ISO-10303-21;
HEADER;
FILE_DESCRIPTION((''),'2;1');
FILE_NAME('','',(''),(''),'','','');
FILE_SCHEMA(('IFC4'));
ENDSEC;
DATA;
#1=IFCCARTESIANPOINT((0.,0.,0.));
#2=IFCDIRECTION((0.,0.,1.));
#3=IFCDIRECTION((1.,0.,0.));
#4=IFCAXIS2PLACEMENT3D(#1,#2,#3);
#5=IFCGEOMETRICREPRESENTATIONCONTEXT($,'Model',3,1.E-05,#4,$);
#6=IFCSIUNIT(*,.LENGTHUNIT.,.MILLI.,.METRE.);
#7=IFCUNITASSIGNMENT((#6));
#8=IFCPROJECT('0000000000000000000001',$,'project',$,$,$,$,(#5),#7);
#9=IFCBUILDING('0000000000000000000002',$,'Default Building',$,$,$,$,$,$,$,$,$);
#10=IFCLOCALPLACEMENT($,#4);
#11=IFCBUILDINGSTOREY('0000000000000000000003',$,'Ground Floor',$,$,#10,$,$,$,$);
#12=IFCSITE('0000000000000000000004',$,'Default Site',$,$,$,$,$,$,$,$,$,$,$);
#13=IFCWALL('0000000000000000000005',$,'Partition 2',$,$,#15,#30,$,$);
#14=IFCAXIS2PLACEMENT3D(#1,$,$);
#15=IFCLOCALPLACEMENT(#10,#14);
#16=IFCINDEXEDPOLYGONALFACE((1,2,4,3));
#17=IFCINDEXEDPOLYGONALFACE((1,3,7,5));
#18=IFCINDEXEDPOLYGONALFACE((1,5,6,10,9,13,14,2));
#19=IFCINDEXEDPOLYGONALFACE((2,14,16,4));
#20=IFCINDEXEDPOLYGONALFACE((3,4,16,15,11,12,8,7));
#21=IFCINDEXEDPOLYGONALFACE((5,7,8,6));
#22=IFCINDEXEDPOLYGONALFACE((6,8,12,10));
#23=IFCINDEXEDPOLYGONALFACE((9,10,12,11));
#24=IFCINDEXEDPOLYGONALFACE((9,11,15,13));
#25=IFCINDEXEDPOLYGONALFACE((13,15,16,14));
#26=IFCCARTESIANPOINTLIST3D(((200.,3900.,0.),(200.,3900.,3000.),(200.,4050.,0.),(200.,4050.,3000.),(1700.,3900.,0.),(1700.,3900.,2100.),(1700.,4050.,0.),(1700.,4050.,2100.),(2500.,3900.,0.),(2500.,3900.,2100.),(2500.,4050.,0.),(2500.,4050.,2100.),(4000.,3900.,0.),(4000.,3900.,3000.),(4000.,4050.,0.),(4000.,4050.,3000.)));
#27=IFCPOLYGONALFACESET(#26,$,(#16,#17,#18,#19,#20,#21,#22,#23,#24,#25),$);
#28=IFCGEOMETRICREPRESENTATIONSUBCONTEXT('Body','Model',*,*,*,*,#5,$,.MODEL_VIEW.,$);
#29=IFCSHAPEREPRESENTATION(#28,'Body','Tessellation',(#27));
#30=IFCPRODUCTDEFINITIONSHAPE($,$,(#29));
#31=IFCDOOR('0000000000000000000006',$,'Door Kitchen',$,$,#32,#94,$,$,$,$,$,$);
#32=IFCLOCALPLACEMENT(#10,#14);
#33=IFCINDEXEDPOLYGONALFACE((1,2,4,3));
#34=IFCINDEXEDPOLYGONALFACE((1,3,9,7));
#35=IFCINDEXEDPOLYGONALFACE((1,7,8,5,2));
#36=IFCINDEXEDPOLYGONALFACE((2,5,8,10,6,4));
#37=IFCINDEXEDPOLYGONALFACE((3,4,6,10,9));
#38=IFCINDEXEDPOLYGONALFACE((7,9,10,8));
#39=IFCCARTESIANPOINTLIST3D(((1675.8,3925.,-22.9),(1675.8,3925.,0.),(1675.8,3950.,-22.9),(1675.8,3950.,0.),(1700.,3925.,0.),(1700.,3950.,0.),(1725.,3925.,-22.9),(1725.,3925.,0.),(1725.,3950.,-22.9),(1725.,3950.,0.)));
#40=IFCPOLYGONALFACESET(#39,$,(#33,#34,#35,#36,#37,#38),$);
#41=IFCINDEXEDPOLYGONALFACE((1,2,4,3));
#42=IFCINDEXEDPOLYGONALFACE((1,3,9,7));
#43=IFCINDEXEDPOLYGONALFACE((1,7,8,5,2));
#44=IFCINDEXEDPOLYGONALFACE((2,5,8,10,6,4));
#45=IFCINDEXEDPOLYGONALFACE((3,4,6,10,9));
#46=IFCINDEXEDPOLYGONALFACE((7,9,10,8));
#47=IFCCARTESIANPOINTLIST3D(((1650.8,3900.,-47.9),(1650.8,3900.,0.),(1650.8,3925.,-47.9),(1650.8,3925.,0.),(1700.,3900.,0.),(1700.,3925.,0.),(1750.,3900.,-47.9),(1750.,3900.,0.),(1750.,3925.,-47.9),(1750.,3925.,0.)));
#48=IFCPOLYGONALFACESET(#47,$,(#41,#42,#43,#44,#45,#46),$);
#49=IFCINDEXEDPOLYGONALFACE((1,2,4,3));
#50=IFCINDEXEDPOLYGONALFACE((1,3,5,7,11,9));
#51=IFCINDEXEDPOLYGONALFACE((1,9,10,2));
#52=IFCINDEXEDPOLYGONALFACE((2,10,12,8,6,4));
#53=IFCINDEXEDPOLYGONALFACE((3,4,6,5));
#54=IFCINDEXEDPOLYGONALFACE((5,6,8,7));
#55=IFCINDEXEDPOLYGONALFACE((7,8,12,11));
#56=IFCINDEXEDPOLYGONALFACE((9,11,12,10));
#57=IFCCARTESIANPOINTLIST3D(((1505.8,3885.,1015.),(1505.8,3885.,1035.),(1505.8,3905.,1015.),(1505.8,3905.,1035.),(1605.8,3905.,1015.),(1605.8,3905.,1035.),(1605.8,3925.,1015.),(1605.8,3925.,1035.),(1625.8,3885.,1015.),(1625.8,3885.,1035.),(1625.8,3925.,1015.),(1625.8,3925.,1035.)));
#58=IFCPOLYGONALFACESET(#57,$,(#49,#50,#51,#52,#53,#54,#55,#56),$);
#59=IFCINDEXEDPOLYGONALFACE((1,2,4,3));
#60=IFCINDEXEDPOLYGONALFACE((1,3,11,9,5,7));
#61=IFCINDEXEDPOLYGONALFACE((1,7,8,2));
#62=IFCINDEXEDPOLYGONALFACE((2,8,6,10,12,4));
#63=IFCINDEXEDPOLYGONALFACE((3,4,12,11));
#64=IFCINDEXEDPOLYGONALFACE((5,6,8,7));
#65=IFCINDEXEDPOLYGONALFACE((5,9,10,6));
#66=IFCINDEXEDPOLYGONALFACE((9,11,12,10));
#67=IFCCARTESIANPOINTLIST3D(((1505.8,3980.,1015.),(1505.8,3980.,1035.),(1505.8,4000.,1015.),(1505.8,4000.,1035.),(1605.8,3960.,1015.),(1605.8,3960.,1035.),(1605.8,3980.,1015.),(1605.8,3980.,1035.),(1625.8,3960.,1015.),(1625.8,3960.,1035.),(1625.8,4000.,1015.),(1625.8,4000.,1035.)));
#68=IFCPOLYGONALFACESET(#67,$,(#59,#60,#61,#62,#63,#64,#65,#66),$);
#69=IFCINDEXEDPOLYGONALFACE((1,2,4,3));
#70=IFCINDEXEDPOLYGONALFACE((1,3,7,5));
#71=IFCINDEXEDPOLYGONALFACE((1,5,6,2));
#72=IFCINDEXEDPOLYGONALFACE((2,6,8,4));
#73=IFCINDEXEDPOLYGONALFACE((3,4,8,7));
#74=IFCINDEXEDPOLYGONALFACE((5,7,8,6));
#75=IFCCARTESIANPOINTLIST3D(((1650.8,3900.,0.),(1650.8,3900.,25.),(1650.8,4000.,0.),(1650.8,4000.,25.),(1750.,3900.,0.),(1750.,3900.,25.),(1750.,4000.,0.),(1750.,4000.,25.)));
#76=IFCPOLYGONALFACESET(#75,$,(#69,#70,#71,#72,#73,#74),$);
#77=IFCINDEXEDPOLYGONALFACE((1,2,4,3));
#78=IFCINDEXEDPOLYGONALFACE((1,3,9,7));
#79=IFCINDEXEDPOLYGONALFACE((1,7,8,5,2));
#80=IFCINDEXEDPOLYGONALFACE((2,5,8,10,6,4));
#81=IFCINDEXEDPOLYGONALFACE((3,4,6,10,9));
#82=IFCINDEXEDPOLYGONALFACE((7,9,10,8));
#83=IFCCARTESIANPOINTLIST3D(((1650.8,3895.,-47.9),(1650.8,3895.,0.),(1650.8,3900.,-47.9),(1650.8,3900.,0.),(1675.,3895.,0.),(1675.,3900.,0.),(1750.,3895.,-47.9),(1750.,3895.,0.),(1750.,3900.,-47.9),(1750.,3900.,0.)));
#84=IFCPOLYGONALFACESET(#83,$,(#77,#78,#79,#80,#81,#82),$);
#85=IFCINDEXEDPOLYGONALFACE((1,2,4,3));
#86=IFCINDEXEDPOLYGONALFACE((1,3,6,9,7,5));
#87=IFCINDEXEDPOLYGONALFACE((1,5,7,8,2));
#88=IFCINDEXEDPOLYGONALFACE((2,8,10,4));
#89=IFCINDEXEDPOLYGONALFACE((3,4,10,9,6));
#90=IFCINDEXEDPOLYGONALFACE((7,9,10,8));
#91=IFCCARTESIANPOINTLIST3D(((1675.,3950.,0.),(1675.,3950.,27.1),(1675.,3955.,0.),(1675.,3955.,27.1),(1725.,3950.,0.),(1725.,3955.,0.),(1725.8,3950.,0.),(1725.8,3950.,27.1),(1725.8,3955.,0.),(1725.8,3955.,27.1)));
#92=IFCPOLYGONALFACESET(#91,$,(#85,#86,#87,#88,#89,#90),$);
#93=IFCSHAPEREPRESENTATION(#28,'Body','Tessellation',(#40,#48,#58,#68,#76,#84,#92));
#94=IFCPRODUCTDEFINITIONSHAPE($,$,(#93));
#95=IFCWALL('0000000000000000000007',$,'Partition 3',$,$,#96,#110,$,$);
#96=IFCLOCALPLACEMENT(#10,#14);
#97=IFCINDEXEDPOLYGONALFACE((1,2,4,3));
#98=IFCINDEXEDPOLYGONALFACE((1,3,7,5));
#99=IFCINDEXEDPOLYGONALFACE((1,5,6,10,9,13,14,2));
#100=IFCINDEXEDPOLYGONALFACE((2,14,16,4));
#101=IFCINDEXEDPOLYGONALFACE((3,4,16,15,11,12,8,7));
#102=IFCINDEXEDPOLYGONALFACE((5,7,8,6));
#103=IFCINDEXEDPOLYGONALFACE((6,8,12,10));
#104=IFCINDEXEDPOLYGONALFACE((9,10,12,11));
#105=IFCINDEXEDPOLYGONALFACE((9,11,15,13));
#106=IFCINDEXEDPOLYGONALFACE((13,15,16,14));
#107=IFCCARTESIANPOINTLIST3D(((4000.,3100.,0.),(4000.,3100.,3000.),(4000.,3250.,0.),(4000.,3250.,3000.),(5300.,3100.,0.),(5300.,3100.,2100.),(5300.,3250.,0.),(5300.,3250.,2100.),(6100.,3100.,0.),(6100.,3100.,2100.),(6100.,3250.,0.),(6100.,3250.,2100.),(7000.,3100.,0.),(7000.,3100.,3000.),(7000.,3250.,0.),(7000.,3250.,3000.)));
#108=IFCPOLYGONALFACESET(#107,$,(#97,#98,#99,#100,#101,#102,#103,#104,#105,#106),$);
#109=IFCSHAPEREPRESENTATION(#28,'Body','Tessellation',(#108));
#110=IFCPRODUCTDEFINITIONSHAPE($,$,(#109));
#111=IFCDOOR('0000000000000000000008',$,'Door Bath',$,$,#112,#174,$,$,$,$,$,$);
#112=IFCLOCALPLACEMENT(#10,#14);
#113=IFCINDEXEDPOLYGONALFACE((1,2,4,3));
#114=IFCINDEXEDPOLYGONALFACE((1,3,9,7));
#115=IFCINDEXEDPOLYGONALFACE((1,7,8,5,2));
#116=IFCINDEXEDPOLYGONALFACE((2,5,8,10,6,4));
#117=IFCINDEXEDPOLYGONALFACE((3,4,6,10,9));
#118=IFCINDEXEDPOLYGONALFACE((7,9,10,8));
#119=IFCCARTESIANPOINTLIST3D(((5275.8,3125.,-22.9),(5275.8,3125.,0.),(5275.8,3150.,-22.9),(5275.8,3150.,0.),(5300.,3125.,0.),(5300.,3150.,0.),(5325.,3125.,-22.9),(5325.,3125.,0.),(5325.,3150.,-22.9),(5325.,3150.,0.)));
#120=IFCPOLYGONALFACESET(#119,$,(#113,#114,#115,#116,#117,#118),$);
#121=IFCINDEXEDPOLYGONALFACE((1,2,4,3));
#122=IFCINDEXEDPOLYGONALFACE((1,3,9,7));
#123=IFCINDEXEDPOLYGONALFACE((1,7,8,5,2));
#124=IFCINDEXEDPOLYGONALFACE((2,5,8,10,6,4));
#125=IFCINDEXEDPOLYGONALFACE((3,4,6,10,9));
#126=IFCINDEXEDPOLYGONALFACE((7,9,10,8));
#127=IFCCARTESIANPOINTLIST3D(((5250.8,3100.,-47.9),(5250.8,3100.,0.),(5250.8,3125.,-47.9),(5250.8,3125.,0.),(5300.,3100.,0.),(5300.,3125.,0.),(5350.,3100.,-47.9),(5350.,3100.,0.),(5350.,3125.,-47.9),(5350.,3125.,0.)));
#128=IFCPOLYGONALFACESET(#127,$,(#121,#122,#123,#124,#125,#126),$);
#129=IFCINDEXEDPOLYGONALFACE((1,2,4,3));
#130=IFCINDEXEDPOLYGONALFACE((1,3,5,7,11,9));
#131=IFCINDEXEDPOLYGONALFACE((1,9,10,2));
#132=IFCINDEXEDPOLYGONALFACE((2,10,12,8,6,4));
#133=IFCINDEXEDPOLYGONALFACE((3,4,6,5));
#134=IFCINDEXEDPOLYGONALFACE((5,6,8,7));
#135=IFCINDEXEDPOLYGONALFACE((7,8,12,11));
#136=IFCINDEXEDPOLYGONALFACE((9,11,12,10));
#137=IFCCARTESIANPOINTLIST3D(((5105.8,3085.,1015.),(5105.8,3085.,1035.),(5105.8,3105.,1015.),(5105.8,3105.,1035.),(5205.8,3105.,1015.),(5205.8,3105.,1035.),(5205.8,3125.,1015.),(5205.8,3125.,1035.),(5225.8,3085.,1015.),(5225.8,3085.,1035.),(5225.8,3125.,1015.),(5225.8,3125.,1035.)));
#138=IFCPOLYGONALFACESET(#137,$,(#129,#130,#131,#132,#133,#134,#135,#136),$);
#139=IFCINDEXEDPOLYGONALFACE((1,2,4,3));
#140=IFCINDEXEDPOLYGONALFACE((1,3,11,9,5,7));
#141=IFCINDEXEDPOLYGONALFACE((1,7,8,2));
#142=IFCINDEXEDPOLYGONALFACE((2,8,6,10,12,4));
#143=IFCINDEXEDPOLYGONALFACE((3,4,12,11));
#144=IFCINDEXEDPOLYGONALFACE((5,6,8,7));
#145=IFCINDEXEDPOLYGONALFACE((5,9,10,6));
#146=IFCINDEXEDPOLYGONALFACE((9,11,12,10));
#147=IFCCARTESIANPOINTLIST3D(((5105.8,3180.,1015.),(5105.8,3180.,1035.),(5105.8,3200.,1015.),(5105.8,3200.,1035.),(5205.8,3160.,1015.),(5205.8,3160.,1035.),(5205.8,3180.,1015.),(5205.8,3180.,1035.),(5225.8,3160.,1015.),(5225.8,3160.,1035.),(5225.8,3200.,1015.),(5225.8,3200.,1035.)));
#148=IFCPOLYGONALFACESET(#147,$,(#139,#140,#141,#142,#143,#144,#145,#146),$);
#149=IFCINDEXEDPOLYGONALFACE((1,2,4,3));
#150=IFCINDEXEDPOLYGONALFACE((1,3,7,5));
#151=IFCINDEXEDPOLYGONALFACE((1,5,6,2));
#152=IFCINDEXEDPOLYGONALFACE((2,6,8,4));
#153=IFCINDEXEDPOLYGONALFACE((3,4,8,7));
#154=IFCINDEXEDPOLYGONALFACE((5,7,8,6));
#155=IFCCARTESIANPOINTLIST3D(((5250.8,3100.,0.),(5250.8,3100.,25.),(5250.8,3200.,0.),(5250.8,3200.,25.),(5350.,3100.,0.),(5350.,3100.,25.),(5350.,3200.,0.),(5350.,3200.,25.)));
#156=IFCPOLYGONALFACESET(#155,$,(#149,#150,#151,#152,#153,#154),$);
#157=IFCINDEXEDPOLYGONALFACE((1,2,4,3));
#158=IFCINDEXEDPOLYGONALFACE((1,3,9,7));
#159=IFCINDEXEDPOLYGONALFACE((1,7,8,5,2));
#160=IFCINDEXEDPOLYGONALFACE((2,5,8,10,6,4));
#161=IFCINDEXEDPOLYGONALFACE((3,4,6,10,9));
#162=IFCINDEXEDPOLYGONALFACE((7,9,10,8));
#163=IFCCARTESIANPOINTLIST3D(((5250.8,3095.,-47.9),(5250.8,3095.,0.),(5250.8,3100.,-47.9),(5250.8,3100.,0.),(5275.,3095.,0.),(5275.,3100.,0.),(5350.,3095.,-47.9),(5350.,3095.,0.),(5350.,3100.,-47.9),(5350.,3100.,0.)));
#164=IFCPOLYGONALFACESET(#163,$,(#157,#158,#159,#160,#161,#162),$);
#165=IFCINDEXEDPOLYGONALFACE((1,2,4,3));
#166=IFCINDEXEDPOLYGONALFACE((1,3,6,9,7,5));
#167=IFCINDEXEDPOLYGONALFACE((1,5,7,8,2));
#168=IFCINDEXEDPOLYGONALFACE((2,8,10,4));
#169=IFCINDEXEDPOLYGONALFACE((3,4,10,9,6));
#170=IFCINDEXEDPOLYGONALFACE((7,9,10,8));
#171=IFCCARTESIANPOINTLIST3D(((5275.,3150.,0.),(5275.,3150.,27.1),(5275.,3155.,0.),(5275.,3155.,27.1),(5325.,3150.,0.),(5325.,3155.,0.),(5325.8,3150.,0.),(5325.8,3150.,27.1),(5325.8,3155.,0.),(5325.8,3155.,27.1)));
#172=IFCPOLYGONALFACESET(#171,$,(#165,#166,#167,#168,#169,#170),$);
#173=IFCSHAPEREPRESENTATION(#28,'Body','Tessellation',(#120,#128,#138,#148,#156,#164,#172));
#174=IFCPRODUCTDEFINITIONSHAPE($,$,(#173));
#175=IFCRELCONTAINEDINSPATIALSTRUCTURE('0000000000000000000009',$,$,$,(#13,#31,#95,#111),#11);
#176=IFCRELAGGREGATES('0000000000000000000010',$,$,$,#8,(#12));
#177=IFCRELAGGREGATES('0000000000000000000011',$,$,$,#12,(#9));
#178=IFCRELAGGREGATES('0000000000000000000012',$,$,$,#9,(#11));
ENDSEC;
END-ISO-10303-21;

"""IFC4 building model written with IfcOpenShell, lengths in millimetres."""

from ifc_helpers import new_model, si_unit, frame, origin_with_axes, place, context, subcontext, project, spatial, line, indexed_curve, outline, extrude, element, fill, save


model = new_model("IFC4")

# Units and contexts
model_context = context("Model", 3, precision=1e-05, world=origin_with_axes())
body_context = subcontext(model_context, "Body", "Model", "MODEL_VIEW")
ifc_project = project(units=[si_unit("LENGTHUNIT", "METRE", prefix="MILLI")], contexts=[model_context])

# Site, building, storey
site = spatial("IfcSite", under=ifc_project, Name="Default Site")
building = spatial("IfcBuilding", under=site, Name="Default Building")
storey_placement = place(None, origin_with_axes())
storey = spatial("IfcBuildingStorey", under=building, at=storey_placement, Name="Ground Floor")

# Walls, openings, doors
wall_1_placement = place(storey_placement, origin_with_axes())
wall_1 = element("IfcWall", 1, at=wall_1_placement, inside=storey, Name="Partition 2", context=body_context, shape_type="SweptSolid", body=[
    extrude(outline(indexed_curve([(200.0, 3900.0), (4000.0, 3900.0), (4000.0, 4050.0), (200.0, 4050.0), (200.0, 3900.0)])), None, (0.0, 0.0, 1.0), 3000.0),
])
opening_1_placement = place(wall_1_placement, origin_with_axes())
opening_1 = element("IfcOpeningElement", 2, at=opening_1_placement, cuts=wall_1, context=body_context, shape_type="SweptSolid", body=[
    extrude(outline(indexed_curve([(1700.0, 3900.0), (2500.0, 3900.0), (2500.0, 4050.0), (1700.0, 4050.0), (1700.0, 3900.0)])), None, (0.0, 0.0, 1.0), 2100.0),
])
door_1_placement = place(storey_placement, frame((1700.0, 3900.0, 0.0), z_axis=(0.0, 0.0, 1.0), x_axis=(1.0, 0.0, 0.0)))
door_1 = element("IfcDoor", 3, at=door_1_placement, inside=storey, Name="Door Kitchen", context=body_context, shape_type="SweptSolid", body=[
    extrude(outline(indexed_curve([(0.0, 0.0), (0.0, 2.1), (0.8, 2.1), (0.8, 0.0), (-24.2, 0.0), (-24.2, -22.9), (25.0, -22.9), (25.0, 0.0)], segments=[line(1, 2, 3, 4, 5, 6, 7, 8, 1)])), frame((0.0, 25.0, 0.0), z_axis=(0.0, -1.0, 0.0), x_axis=(1.0, 0.0, 0.0)), (0.0, 0.0, -1.0), 25.0),
    extrude(outline(indexed_curve([(0.0, 0.0), (0.0, 2.1), (0.8, 2.1), (0.8, 0.0), (-49.2, 0.0), (-49.2, -47.9), (50.0, -47.9), (50.0, 0.0)], segments=[line(1, 2, 3, 4, 5, 6, 7, 8, 1)])), frame((0.0, 0.0, 0.0), z_axis=(0.0, -1.0, 0.0), x_axis=(1.0, 0.0, 0.0)), (0.0, 0.0, -1.0), 25.0),
    extrude(outline(indexed_curve([(0.0, 0.0), (-49.2, 0.0), (-49.2, 35.0), (0.0, 35.0)], segments=[line(1, 2, 3, 4, 1)])), frame((25.0, 25.0, 25.0), z_axis=(0.0, 0.0, 1.0), x_axis=(1.0, 0.0, 0.0)), (0.0, 0.0, 1.0), -47.9),
    extrude(outline(indexed_curve([(0.0, 0.0), (0.0, -40.0), (-120.0, -40.0), (-120.0, -20.0), (-20.0, -20.0), (-20.0, 0.0)], segments=[line(1, 2, 3, 4, 5, 6, 1)])), frame((-74.2, 25.0, 1015.0), z_axis=(0.0, 0.0, 1.0), x_axis=(1.0, 0.0, 0.0)), (0.0, 0.0, 1.0), 20.0),
    extrude(outline(indexed_curve([(0.0, 0.0), (0.0, 40.0), (-120.0, 40.0), (-120.0, 20.0), (-20.0, 20.0), (-20.0, 0.0)], segments=[line(1, 2, 3, 4, 5, 6, 1)])), frame((-74.2, 60.0, 1015.0), z_axis=(0.0, 0.0, 1.0), x_axis=(1.0, 0.0, 0.0)), (0.0, 0.0, 1.0), 20.0),
    extrude(outline(indexed_curve([(0.0, 0.0), (-99.2, 0.0), (-99.2, 100.0), (0.0, 100.0)], segments=[line(1, 2, 3, 4, 1)])), frame((50.0, 0.0, 0.0), z_axis=(0.0, 0.0, 1.0), x_axis=(1.0, 0.0, 0.0)), (0.0, 0.0, 1.0), 25.0),
    extrude(outline(indexed_curve([(0.0, 0.0), (0.0, 27.1), (50.8, 27.1), (50.8, 0.0), (-24.2, 0.0), (-24.2, -47.9), (75.0, -47.9), (75.0, 0.0)], segments=[line(1, 2, 3, 4, 5, 6, 7, 8, 1)])), frame((-25.0, -5.0, 0.0), z_axis=(0.0, -1.0, 0.0), x_axis=(1.0, 0.0, 0.0)), (0.0, 0.0, -1.0), 5.0),
    extrude(outline(indexed_curve([(0.0, 0.0), (0.0, 27.1), (50.8, 27.1), (50.8, 0.0), (0.8, 0.0), (0.8, -22.9), (50.0, -22.9), (50.0, 0.0)], segments=[line(1, 2, 3, 4, 5, 6, 7, 8, 1)])), frame((-25.0, 50.0, 0.0), z_axis=(0.0, -1.0, 0.0), x_axis=(1.0, 0.0, 0.0)), (0.0, 0.0, -1.0), 5.0),
])
fill(opening_1, door_1)
wall_2_placement = place(storey_placement, origin_with_axes())
wall_2 = element("IfcWall", 4, at=wall_2_placement, inside=storey, Name="Partition 3", context=body_context, shape_type="SweptSolid", body=[
    extrude(outline(indexed_curve([(4000.0, 3100.0), (7000.0, 3100.0), (7000.0, 3250.0), (4000.0, 3250.0), (4000.0, 3100.0)])), None, (0.0, 0.0, 1.0), 3000.0),
])
opening_2_placement = place(wall_2_placement, origin_with_axes())
opening_2 = element("IfcOpeningElement", 5, at=opening_2_placement, cuts=wall_2, context=body_context, shape_type="SweptSolid", body=[
    extrude(outline(indexed_curve([(5300.0, 3100.0), (6100.0, 3100.0), (6100.0, 3250.0), (5300.0, 3250.0), (5300.0, 3100.0)])), None, (0.0, 0.0, 1.0), 2100.0),
])
door_2_placement = place(storey_placement, frame((5300.0, 3100.0, 0.0), z_axis=(0.0, 0.0, 1.0), x_axis=(1.0, 0.0, 0.0)))
door_2 = element("IfcDoor", 6, at=door_2_placement, inside=storey, Name="Door Bath", context=body_context, shape_type="SweptSolid", body=[
    extrude(outline(indexed_curve([(0.0, 0.0), (0.0, 2.1), (0.8, 2.1), (0.8, 0.0), (-24.2, 0.0), (-24.2, -22.9), (25.0, -22.9), (25.0, 0.0)], segments=[line(1, 2, 3, 4, 5, 6, 7, 8, 1)])), frame((0.0, 25.0, 0.0), z_axis=(0.0, -1.0, 0.0), x_axis=(1.0, 0.0, 0.0)), (0.0, 0.0, -1.0), 25.0),
    extrude(outline(indexed_curve([(0.0, 0.0), (0.0, 2.1), (0.8, 2.1), (0.8, 0.0), (-49.2, 0.0), (-49.2, -47.9), (50.0, -47.9), (50.0, 0.0)], segments=[line(1, 2, 3, 4, 5, 6, 7, 8, 1)])), frame((0.0, 0.0, 0.0), z_axis=(0.0, -1.0, 0.0), x_axis=(1.0, 0.0, 0.0)), (0.0, 0.0, -1.0), 25.0),
    extrude(outline(indexed_curve([(0.0, 0.0), (-49.2, 0.0), (-49.2, 35.0), (0.0, 35.0)], segments=[line(1, 2, 3, 4, 1)])), frame((25.0, 25.0, 25.0), z_axis=(0.0, 0.0, 1.0), x_axis=(1.0, 0.0, 0.0)), (0.0, 0.0, 1.0), -47.9),
    extrude(outline(indexed_curve([(0.0, 0.0), (0.0, -40.0), (-120.0, -40.0), (-120.0, -20.0), (-20.0, -20.0), (-20.0, 0.0)], segments=[line(1, 2, 3, 4, 5, 6, 1)])), frame((-74.2, 25.0, 1015.0), z_axis=(0.0, 0.0, 1.0), x_axis=(1.0, 0.0, 0.0)), (0.0, 0.0, 1.0), 20.0),
    extrude(outline(indexed_curve([(0.0, 0.0), (0.0, 40.0), (-120.0, 40.0), (-120.0, 20.0), (-20.0, 20.0), (-20.0, 0.0)], segments=[line(1, 2, 3, 4, 5, 6, 1)])), frame((-74.2, 60.0, 1015.0), z_axis=(0.0, 0.0, 1.0), x_axis=(1.0, 0.0, 0.0)), (0.0, 0.0, 1.0), 20.0),
    extrude(outline(indexed_curve([(0.0, 0.0), (-99.2, 0.0), (-99.2, 100.0), (0.0, 100.0)], segments=[line(1, 2, 3, 4, 1)])), frame((50.0, 0.0, 0.0), z_axis=(0.0, 0.0, 1.0), x_axis=(1.0, 0.0, 0.0)), (0.0, 0.0, 1.0), 25.0),
    extrude(outline(indexed_curve([(0.0, 0.0), (0.0, 27.1), (50.8, 27.1), (50.8, 0.0), (-24.2, 0.0), (-24.2, -47.9), (75.0, -47.9), (75.0, 0.0)], segments=[line(1, 2, 3, 4, 5, 6, 7, 8, 1)])), frame((-25.0, -5.0, 0.0), z_axis=(0.0, -1.0, 0.0), x_axis=(1.0, 0.0, 0.0)), (0.0, 0.0, -1.0), 5.0),
    extrude(outline(indexed_curve([(0.0, 0.0), (0.0, 27.1), (50.8, 27.1), (50.8, 0.0), (0.8, 0.0), (0.8, -22.9), (50.0, -22.9), (50.0, 0.0)], segments=[line(1, 2, 3, 4, 5, 6, 7, 8, 1)])), frame((-25.0, 50.0, 0.0), z_axis=(0.0, -1.0, 0.0), x_axis=(1.0, 0.0, 0.0)), (0.0, 0.0, -1.0), 5.0),
])
fill(opening_2, door_2)

save(model, "model.ifc")
